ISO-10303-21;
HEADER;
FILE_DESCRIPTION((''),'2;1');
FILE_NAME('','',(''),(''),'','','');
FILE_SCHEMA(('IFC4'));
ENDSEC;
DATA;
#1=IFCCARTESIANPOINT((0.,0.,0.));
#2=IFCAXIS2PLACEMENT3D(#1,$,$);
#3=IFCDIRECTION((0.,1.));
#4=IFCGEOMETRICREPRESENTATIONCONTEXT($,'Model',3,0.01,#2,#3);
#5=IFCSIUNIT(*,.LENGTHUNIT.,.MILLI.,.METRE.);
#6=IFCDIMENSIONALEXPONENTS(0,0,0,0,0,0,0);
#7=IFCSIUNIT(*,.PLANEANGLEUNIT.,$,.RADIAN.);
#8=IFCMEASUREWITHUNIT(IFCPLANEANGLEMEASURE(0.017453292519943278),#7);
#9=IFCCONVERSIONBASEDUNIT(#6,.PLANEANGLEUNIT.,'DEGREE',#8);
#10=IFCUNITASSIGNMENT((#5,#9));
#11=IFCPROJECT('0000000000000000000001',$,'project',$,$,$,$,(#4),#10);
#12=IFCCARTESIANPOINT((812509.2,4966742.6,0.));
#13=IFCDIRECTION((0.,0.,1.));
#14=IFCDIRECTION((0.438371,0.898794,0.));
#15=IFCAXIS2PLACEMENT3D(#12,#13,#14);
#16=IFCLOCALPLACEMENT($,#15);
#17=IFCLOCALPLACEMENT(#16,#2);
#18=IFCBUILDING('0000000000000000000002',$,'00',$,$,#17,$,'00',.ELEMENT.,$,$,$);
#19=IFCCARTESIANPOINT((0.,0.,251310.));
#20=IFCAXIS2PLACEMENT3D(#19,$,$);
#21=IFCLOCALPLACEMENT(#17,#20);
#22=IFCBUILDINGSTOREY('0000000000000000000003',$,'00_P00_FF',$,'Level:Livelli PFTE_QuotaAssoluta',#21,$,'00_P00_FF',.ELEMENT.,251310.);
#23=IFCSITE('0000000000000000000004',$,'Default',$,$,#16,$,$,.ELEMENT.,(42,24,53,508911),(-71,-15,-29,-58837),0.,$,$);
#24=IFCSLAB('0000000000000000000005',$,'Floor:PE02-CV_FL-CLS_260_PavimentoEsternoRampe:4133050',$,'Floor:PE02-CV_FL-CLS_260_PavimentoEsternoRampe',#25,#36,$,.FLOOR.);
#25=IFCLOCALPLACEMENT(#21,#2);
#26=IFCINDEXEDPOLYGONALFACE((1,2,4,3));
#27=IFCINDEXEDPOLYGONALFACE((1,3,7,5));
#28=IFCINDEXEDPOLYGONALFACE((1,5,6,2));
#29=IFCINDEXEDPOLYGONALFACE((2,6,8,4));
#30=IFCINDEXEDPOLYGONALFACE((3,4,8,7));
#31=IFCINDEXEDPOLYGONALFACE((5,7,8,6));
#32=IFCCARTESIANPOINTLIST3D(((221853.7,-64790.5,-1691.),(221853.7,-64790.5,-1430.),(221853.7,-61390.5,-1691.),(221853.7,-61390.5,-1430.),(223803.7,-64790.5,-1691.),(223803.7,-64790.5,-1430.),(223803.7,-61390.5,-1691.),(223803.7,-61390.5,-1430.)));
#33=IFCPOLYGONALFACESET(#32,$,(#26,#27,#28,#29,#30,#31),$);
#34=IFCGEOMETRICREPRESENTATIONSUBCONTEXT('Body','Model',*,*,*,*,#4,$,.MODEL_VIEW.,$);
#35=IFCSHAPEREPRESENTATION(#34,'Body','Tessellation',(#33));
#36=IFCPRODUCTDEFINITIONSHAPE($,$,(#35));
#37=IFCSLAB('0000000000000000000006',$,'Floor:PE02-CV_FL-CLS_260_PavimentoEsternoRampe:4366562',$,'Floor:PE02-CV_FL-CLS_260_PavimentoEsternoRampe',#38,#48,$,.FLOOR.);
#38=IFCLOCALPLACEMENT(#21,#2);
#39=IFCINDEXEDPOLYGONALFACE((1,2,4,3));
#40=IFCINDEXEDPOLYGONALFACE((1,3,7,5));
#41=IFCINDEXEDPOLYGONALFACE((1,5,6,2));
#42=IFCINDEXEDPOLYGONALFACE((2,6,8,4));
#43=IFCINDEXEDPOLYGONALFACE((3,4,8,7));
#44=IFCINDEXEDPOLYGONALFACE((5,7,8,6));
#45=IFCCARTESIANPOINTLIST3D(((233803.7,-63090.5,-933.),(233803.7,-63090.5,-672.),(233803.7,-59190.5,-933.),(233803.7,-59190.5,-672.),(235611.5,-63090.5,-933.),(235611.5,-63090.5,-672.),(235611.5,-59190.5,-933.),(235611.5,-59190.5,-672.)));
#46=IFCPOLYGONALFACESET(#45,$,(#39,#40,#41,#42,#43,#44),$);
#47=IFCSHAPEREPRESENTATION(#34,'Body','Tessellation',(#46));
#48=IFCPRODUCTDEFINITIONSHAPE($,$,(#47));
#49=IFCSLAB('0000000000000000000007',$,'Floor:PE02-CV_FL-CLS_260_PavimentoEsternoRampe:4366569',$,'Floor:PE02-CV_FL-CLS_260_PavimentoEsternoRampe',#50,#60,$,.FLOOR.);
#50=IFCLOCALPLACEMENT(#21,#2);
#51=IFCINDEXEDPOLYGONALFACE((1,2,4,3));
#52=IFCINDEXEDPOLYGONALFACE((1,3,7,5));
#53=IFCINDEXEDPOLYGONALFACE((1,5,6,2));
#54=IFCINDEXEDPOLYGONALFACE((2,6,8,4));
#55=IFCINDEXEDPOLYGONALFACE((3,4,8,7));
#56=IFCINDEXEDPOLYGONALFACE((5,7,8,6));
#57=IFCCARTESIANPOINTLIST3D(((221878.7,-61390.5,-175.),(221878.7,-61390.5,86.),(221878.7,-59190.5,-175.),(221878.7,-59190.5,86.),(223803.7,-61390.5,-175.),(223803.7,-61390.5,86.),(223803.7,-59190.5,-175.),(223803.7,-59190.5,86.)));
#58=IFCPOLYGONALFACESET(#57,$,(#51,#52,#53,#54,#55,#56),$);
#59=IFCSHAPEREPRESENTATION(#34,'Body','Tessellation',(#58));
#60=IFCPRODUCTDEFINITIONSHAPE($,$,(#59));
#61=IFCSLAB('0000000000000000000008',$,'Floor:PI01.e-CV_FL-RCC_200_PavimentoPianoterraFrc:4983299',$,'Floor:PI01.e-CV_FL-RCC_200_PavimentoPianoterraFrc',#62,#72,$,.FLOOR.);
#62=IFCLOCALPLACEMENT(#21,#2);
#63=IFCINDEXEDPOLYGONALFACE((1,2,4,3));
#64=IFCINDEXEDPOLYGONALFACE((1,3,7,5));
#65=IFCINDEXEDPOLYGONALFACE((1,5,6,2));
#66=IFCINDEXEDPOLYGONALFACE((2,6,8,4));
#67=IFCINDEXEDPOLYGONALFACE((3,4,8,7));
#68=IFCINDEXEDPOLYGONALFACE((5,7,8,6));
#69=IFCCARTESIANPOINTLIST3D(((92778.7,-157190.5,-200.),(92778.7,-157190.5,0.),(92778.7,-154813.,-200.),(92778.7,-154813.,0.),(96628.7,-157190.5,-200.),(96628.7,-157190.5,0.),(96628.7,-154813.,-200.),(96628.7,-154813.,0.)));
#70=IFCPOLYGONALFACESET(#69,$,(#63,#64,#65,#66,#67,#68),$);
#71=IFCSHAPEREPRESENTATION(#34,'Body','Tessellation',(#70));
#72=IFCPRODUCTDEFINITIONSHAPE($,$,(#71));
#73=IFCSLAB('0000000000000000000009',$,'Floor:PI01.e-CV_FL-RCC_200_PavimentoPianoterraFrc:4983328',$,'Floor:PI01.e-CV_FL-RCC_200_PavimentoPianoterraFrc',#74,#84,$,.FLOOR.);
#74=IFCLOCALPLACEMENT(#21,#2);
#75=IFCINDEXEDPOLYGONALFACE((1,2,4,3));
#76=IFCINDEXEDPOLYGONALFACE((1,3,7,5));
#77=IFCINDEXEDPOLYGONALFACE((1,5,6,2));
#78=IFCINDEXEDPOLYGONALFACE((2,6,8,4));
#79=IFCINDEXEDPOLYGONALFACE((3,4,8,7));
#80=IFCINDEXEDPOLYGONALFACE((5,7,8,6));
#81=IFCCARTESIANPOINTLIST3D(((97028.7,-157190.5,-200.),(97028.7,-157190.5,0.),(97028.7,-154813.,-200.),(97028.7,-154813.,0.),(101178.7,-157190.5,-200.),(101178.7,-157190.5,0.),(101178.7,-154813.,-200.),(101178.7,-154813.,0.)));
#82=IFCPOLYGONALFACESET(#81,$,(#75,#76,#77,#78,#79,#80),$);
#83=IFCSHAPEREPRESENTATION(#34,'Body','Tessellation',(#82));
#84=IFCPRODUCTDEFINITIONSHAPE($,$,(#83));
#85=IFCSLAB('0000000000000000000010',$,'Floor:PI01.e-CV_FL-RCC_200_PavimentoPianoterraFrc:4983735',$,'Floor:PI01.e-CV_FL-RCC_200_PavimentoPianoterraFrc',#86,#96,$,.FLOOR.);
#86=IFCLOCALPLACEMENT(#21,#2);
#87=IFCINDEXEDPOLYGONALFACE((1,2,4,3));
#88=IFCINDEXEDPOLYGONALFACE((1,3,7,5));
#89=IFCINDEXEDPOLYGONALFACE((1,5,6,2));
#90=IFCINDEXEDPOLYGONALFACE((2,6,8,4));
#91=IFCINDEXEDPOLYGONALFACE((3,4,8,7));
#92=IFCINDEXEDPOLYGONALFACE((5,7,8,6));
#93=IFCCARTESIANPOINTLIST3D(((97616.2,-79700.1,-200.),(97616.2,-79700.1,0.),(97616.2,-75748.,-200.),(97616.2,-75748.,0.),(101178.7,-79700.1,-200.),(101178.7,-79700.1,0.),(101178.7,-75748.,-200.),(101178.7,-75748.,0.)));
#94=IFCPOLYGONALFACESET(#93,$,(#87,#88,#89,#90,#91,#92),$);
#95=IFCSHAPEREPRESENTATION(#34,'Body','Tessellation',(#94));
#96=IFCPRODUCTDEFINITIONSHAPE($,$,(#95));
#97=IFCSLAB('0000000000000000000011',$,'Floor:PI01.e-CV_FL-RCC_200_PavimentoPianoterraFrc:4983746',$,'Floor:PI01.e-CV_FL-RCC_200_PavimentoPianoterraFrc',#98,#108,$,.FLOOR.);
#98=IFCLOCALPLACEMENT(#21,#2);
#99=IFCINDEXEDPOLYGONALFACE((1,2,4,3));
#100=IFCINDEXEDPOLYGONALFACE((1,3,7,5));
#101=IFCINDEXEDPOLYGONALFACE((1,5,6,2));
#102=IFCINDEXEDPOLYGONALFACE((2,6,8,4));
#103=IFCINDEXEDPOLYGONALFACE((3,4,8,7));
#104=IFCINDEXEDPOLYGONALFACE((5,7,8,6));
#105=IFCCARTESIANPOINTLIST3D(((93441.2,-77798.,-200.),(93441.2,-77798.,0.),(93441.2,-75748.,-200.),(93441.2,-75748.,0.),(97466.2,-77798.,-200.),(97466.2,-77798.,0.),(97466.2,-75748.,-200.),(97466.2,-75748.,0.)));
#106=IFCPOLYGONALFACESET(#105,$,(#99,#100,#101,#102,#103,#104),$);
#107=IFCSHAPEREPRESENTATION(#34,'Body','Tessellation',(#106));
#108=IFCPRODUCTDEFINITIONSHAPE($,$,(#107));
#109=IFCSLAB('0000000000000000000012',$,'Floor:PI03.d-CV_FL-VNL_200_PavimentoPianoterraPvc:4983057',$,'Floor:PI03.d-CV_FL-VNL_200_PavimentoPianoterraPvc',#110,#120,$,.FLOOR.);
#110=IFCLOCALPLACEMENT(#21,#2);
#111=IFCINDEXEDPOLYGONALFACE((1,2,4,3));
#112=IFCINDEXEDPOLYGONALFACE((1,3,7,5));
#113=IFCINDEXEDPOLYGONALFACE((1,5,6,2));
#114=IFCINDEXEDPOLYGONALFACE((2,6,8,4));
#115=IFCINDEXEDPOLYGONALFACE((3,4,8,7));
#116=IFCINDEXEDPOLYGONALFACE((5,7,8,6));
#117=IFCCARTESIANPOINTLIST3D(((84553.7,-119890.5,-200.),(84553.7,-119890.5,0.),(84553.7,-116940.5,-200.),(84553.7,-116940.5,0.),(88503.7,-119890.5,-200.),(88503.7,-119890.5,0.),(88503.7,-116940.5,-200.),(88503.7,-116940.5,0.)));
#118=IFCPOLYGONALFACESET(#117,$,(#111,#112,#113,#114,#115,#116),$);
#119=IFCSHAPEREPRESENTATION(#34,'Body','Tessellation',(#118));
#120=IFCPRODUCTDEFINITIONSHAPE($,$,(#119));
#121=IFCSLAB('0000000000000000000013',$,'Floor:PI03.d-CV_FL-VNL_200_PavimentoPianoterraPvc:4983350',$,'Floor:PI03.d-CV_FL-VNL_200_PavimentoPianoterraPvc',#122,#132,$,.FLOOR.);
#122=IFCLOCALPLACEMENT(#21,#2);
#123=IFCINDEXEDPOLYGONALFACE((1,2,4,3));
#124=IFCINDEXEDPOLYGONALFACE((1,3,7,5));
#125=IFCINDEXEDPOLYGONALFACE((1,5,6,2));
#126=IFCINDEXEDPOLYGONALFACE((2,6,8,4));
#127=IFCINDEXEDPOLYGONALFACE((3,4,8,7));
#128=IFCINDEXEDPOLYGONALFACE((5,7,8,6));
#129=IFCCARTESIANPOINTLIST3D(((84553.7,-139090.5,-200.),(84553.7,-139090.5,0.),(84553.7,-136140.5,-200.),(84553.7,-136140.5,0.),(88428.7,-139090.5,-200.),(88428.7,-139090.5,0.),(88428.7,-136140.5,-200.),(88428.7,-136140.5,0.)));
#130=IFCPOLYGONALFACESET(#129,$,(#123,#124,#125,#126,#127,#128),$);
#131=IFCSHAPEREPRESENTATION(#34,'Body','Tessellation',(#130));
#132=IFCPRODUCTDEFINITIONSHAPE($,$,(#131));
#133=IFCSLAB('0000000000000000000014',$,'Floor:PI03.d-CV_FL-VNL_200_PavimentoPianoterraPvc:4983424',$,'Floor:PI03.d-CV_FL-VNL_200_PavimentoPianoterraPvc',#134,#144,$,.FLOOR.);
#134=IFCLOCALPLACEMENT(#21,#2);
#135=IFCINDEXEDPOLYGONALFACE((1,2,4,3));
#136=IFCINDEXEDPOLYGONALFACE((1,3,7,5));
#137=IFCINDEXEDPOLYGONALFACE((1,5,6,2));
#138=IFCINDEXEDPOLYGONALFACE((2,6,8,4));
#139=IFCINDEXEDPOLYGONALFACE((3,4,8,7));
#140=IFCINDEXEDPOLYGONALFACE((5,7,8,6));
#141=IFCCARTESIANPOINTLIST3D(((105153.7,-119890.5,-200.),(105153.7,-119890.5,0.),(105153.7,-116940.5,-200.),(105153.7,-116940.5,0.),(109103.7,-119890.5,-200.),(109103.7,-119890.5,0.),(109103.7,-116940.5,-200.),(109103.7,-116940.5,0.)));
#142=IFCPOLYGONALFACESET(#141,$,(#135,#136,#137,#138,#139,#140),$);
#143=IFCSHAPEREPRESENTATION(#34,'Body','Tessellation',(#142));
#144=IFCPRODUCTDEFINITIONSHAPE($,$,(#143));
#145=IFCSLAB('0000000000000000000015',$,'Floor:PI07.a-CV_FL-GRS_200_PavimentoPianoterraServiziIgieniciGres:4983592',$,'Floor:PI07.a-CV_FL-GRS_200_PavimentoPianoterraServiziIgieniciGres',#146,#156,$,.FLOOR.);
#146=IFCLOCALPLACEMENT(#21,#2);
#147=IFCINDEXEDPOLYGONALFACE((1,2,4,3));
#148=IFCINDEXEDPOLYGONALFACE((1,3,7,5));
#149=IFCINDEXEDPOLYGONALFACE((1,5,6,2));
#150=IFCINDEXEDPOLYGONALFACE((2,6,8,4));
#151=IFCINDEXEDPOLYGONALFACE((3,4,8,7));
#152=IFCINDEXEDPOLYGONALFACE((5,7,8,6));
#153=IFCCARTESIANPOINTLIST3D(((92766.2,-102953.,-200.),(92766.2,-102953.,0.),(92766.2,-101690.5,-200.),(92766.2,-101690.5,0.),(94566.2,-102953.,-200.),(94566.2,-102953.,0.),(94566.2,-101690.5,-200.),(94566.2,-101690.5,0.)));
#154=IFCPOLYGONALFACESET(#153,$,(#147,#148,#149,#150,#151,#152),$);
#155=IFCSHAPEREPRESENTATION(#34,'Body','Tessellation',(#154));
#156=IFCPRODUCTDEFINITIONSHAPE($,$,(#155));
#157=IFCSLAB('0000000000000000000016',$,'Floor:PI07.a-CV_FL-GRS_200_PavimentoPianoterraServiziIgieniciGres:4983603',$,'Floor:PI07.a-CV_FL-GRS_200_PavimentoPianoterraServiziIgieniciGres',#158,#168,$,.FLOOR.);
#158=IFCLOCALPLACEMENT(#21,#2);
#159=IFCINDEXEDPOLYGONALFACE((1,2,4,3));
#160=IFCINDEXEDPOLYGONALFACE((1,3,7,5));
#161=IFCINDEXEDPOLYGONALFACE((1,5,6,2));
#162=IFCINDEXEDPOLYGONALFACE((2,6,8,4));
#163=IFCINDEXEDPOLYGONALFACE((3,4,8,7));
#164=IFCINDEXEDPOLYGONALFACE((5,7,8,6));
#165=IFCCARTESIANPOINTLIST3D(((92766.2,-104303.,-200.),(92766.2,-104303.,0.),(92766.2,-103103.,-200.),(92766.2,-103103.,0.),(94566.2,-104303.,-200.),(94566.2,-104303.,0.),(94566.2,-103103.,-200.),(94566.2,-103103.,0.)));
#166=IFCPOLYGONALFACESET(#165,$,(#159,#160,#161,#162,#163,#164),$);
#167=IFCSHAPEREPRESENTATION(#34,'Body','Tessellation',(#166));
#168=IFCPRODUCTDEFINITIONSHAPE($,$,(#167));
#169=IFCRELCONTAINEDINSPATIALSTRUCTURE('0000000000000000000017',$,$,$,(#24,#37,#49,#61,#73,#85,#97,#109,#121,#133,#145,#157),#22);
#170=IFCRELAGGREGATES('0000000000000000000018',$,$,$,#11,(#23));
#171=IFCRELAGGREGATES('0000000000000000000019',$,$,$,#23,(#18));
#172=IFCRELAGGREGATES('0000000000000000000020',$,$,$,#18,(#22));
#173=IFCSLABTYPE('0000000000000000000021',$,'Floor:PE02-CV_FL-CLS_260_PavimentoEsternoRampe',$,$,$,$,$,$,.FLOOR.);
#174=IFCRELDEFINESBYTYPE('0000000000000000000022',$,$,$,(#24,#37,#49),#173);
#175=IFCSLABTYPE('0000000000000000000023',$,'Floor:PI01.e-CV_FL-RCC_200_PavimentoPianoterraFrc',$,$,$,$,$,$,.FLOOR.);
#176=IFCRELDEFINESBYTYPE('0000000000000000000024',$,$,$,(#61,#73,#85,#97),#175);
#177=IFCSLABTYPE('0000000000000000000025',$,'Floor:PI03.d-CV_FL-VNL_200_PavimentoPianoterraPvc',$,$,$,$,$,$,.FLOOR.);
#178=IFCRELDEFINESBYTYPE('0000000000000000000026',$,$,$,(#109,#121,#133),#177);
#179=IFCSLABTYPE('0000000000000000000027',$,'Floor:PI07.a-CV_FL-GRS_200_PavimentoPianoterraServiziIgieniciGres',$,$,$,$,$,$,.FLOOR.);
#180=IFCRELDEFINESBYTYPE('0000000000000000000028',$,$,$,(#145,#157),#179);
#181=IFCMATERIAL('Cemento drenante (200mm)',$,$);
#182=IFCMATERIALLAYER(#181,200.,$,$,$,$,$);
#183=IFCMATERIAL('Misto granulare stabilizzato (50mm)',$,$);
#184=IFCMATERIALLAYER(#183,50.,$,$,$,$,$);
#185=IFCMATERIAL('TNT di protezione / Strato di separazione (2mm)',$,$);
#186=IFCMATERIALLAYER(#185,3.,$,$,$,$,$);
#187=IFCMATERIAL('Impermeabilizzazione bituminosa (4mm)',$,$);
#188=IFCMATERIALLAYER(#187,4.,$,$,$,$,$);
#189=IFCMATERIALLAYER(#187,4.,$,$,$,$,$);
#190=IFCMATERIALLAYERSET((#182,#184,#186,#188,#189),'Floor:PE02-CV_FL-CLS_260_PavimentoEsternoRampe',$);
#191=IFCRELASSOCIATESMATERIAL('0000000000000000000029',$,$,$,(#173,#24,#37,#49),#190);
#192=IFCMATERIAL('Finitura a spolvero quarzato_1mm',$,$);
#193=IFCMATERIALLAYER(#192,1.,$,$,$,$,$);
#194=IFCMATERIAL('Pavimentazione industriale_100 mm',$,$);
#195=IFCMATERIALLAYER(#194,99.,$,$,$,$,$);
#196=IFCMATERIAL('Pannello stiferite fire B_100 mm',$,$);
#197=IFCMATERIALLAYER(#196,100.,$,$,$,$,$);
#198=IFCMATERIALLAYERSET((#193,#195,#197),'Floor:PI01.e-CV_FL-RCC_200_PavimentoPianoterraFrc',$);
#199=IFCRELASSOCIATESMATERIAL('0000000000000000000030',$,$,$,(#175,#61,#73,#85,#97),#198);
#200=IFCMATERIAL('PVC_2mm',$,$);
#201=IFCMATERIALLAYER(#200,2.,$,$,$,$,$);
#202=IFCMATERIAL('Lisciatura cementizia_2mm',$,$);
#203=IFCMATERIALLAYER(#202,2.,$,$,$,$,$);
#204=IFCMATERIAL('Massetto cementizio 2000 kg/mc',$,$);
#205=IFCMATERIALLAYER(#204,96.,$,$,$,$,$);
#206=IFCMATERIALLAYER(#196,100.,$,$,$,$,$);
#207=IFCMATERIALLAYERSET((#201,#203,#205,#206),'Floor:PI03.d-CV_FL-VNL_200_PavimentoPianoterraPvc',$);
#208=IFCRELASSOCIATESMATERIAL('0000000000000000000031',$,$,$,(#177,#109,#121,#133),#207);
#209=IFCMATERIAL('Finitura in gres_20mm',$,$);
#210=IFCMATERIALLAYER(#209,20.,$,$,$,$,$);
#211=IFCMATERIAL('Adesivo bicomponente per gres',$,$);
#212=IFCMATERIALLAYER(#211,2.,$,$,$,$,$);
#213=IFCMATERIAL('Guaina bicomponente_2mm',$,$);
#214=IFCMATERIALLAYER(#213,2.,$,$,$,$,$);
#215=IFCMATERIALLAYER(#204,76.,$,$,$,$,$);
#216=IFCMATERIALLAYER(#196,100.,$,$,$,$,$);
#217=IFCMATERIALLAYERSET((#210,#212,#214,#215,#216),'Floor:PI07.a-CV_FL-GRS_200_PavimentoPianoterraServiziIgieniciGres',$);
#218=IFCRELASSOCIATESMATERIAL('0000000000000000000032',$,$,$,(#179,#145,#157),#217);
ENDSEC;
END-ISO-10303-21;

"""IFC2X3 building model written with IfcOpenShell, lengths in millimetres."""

from ifc_helpers import new_model, entity, si_unit, converted_unit, direction, frame, frame_2d, origin, origin_2d_with_axis, place, context, subcontext, project, spatial, rectangle, extrude, material, layer, layer_set, layer_usage, type_object, element, save


model = new_model("IFC2X3")

# Units and contexts
model_context = context("Model", 3, precision=0.01, world=origin(), true_north=direction((0.0, 1.0)))
body_context = subcontext(model_context, "Body", "Model", "MODEL_VIEW")
ifc_project = project(units=[si_unit("LENGTHUNIT", "METRE", prefix="MILLI"), converted_unit("PLANEANGLEUNIT", "DEGREE", entity("IfcPlaneAngleMeasure", 0.017453292519943278), si_unit("PLANEANGLEUNIT", "RADIAN"), dimensions=[0, 0, 0, 0, 0, 0, 0])], contexts=[model_context])

# Site, building, storey
site_placement = place(None, frame((812509.2, 4966742.6, 0.0), z_axis=(0.0, 0.0, 1.0), x_axis=(0.438371, 0.898794, 0.0)))
site = spatial("IfcSite", under=ifc_project, at=site_placement, Name="Default", CompositionType="ELEMENT", RefLatitude=(42, 24, 53, 508911), RefLongitude=(-71, -15, -29, -58837), RefElevation=0.0)
building_placement = place(site_placement, origin())
building = spatial("IfcBuilding", under=site, at=building_placement, Name="00", LongName="00", CompositionType="ELEMENT")
storey_placement = place(building_placement, frame((0.0, 0.0, 251310.0)))
storey = spatial("IfcBuildingStorey", under=building, at=storey_placement, Name="00_P00_FF", ObjectType="Level:Livelli PFTE_QuotaAssoluta", LongName="00_P00_FF", CompositionType="ELEMENT", Elevation=251310.0)

# Slabs
ifc_material_1 = material(Name="Massetto cementizio 2000 kg/mc")
ifc_material_2 = material(Name="Pannello stiferite fire B_100 mm")
ifc_material_3 = material(Name="Cemento drenante (200mm)")
ifc_layer_1 = layer(ifc_material_3, 200.0)
ifc_material_4 = material(Name="Misto granulare stabilizzato (50mm)")
ifc_layer_2 = layer(ifc_material_4, 50.0)
ifc_material_5 = material(Name="TNT di protezione / Strato di separazione (2mm)")
ifc_layer_3 = layer(ifc_material_5, 3.0)
ifc_material_6 = material(Name="Impermeabilizzazione bituminosa (4mm)")
ifc_layer_4 = layer(ifc_material_6, 4.0)
ifc_layer_5 = layer(ifc_material_6, 4.0)
ifc_layer_set_1 = layer_set([ifc_layer_1, ifc_layer_2, ifc_layer_3, ifc_layer_4, ifc_layer_5], Name="Floor:PE02-CV_FL-CLS_260_PavimentoEsternoRampe")
ifc_layer_usage_1 = layer_usage(ifc_layer_set_1, "AXIS3", "POSITIVE", 0.0)
slab_type_1 = type_object("IfcSlabType", Name="Floor:PE02-CV_FL-CLS_260_PavimentoEsternoRampe", PredefinedType="FLOOR", material=ifc_layer_set_1)
slab_1_placement = place(storey_placement, origin())
element("IfcSlab", 1, at=slab_1_placement, inside=storey, type_object=slab_type_1, material=ifc_layer_usage_1, Name="Floor:PE02-CV_FL-CLS_260_PavimentoEsternoRampe:4133050", ObjectType="Floor:PE02-CV_FL-CLS_260_PavimentoEsternoRampe", PredefinedType="FLOOR", context=body_context, shape_type="SweptSolid", body=[
    extrude(rectangle(XDim=3400.0, YDim=1950.0, at=frame_2d((0.0, 0.0), x_axis=(1.0, 0.0))), frame((222828.7, -63090.5, -1430.0), z_axis=(0.0, 0.0, -1.0), x_axis=(0.0, 1.0, 0.0)), (0.0, 0.0, 1.0), 261.0),
])
ifc_layer_usage_2 = layer_usage(ifc_layer_set_1, "AXIS3", "POSITIVE", 0.0)
slab_2_placement = place(storey_placement, origin())
element("IfcSlab", 2, at=slab_2_placement, inside=storey, type_object=slab_type_1, material=ifc_layer_usage_2, Name="Floor:PE02-CV_FL-CLS_260_PavimentoEsternoRampe:4366562", ObjectType="Floor:PE02-CV_FL-CLS_260_PavimentoEsternoRampe", PredefinedType="FLOOR", context=body_context, shape_type="SweptSolid", body=[
    extrude(rectangle(XDim=3900.0, YDim=1807.8, at=origin_2d_with_axis()), frame((234707.6, -61140.5, -672.0), z_axis=(0.0, 0.0, -1.0), x_axis=(0.0, 1.0, 0.0)), (0.0, 0.0, 1.0), 261.0),
])
ifc_layer_usage_3 = layer_usage(ifc_layer_set_1, "AXIS3", "POSITIVE", 0.0)
slab_3_placement = place(storey_placement, origin())
element("IfcSlab", 3, at=slab_3_placement, inside=storey, type_object=slab_type_1, material=ifc_layer_usage_3, Name="Floor:PE02-CV_FL-CLS_260_PavimentoEsternoRampe:4366569", ObjectType="Floor:PE02-CV_FL-CLS_260_PavimentoEsternoRampe", PredefinedType="FLOOR", context=body_context, shape_type="SweptSolid", body=[
    extrude(rectangle(XDim=2200.0, YDim=1925.0, at=frame_2d((0.0, 0.0), x_axis=(1.0, 0.0))), frame((222841.2, -60290.5, 86.0), z_axis=(0.0, 0.0, -1.0), x_axis=(0.0, 1.0, 0.0)), (0.0, 0.0, 1.0), 261.0),
])
ifc_material_7 = material(Name="Finitura a spolvero quarzato_1mm")
ifc_layer_6 = layer(ifc_material_7, 1.0)
ifc_material_8 = material(Name="Pavimentazione industriale_100 mm")
ifc_layer_7 = layer(ifc_material_8, 99.0)
ifc_layer_8 = layer(ifc_material_2, 100.0)
ifc_layer_set_2 = layer_set([ifc_layer_6, ifc_layer_7, ifc_layer_8], Name="Floor:PI01.e-CV_FL-RCC_200_PavimentoPianoterraFrc")
slab_type_2 = type_object("IfcSlabType", Name="Floor:PI01.e-CV_FL-RCC_200_PavimentoPianoterraFrc", PredefinedType="FLOOR", material=ifc_layer_set_2)
ifc_layer_usage_4 = layer_usage(ifc_layer_set_2, "AXIS3", "POSITIVE", 0.0)
slab_4_placement = place(storey_placement, origin())
element("IfcSlab", 4, at=slab_4_placement, inside=storey, type_object=slab_type_2, material=ifc_layer_usage_4, Name="Floor:PI01.e-CV_FL-RCC_200_PavimentoPianoterraFrc:4983299", ObjectType="Floor:PI01.e-CV_FL-RCC_200_PavimentoPianoterraFrc", PredefinedType="FLOOR", context=body_context, shape_type="SweptSolid", body=[
    extrude(rectangle(XDim=2377.5, YDim=3850.0, at=origin_2d_with_axis()), frame((94703.7, -156001.7, 0.0), z_axis=(0.0, 0.0, -1.0), x_axis=(0.0, 1.0, 0.0)), (0.0, 0.0, 1.0), 200.0),
])
ifc_layer_usage_5 = layer_usage(ifc_layer_set_2, "AXIS3", "POSITIVE", 0.0)
slab_5_placement = place(storey_placement, origin())
element("IfcSlab", 5, at=slab_5_placement, inside=storey, type_object=slab_type_2, material=ifc_layer_usage_5, Name="Floor:PI01.e-CV_FL-RCC_200_PavimentoPianoterraFrc:4983328", ObjectType="Floor:PI01.e-CV_FL-RCC_200_PavimentoPianoterraFrc", PredefinedType="FLOOR", context=body_context, shape_type="SweptSolid", body=[
    extrude(rectangle(XDim=2377.5, YDim=4150.0, at=origin_2d_with_axis()), frame((99103.7, -156001.7, 0.0), z_axis=(0.0, 0.0, -1.0), x_axis=(0.0, 1.0, 0.0)), (0.0, 0.0, 1.0), 200.0),
])
ifc_layer_usage_6 = layer_usage(ifc_layer_set_2, "AXIS3", "POSITIVE", 0.0)
slab_6_placement = place(storey_placement, origin())
element("IfcSlab", 6, at=slab_6_placement, inside=storey, type_object=slab_type_2, material=ifc_layer_usage_6, Name="Floor:PI01.e-CV_FL-RCC_200_PavimentoPianoterraFrc:4983735", ObjectType="Floor:PI01.e-CV_FL-RCC_200_PavimentoPianoterraFrc", PredefinedType="FLOOR", context=body_context, shape_type="SweptSolid", body=[
    extrude(rectangle(XDim=3952.2, YDim=3562.5, at=frame_2d((0.0, 0.0), x_axis=(1.0, 0.0))), frame((99397.4, -77724.1, 0.0), z_axis=(0.0, 0.0, -1.0), x_axis=(0.0, 1.0, 0.0)), (0.0, 0.0, 1.0), 200.0),
])
ifc_layer_usage_7 = layer_usage(ifc_layer_set_2, "AXIS3", "POSITIVE", 0.0)
slab_7_placement = place(storey_placement, origin())
element("IfcSlab", 7, at=slab_7_placement, inside=storey, type_object=slab_type_2, material=ifc_layer_usage_7, Name="Floor:PI01.e-CV_FL-RCC_200_PavimentoPianoterraFrc:4983746", ObjectType="Floor:PI01.e-CV_FL-RCC_200_PavimentoPianoterraFrc", PredefinedType="FLOOR", context=body_context, shape_type="SweptSolid", body=[
    extrude(rectangle(XDim=2050.0, YDim=4025.0, at=frame_2d((0.0, 0.0), x_axis=(1.0, 0.0))), frame((95453.7, -76773.0, 0.0), z_axis=(0.0, 0.0, -1.0), x_axis=(0.0, 1.0, 0.0)), (0.0, 0.0, 1.0), 200.0),
])
ifc_material_9 = material(Name="PVC_2mm")
ifc_layer_9 = layer(ifc_material_9, 2.0)
ifc_material_10 = material(Name="Lisciatura cementizia_2mm")
ifc_layer_10 = layer(ifc_material_10, 2.0)
ifc_layer_11 = layer(ifc_material_1, 96.0)
ifc_layer_12 = layer(ifc_material_2, 100.0)
ifc_layer_set_3 = layer_set([ifc_layer_9, ifc_layer_10, ifc_layer_11, ifc_layer_12], Name="Floor:PI03.d-CV_FL-VNL_200_PavimentoPianoterraPvc")
ifc_layer_usage_8 = layer_usage(ifc_layer_set_3, "AXIS3", "POSITIVE", 0.0)
slab_type_3 = type_object("IfcSlabType", Name="Floor:PI03.d-CV_FL-VNL_200_PavimentoPianoterraPvc", PredefinedType="FLOOR", material=ifc_layer_set_3)
slab_8_placement = place(storey_placement, origin())
element("IfcSlab", 8, at=slab_8_placement, inside=storey, type_object=slab_type_3, material=ifc_layer_usage_8, Name="Floor:PI03.d-CV_FL-VNL_200_PavimentoPianoterraPvc:4983057", ObjectType="Floor:PI03.d-CV_FL-VNL_200_PavimentoPianoterraPvc", PredefinedType="FLOOR", context=body_context, shape_type="SweptSolid", body=[
    extrude(rectangle(XDim=2950.0, YDim=3950.0, at=origin_2d_with_axis()), frame((86528.7, -118415.5, 0.0), z_axis=(0.0, 0.0, -1.0), x_axis=(0.0, 1.0, 0.0)), (0.0, 0.0, 1.0), 200.0),
])
ifc_layer_usage_9 = layer_usage(ifc_layer_set_3, "AXIS3", "POSITIVE", 0.0)
slab_9_placement = place(storey_placement, origin())
element("IfcSlab", 9, at=slab_9_placement, inside=storey, type_object=slab_type_3, material=ifc_layer_usage_9, Name="Floor:PI03.d-CV_FL-VNL_200_PavimentoPianoterraPvc:4983350", ObjectType="Floor:PI03.d-CV_FL-VNL_200_PavimentoPianoterraPvc", PredefinedType="FLOOR", context=body_context, shape_type="SweptSolid", body=[
    extrude(rectangle(XDim=2950.0, YDim=3875.0, at=origin_2d_with_axis()), frame((86491.2, -137615.5, 0.0), z_axis=(0.0, 0.0, -1.0), x_axis=(0.0, 1.0, 0.0)), (0.0, 0.0, 1.0), 200.0),
])
ifc_layer_usage_10 = layer_usage(ifc_layer_set_3, "AXIS3", "POSITIVE", 0.0)
slab_10_placement = place(storey_placement, origin())
element("IfcSlab", 10, at=slab_10_placement, inside=storey, type_object=slab_type_3, material=ifc_layer_usage_10, Name="Floor:PI03.d-CV_FL-VNL_200_PavimentoPianoterraPvc:4983424", ObjectType="Floor:PI03.d-CV_FL-VNL_200_PavimentoPianoterraPvc", PredefinedType="FLOOR", context=body_context, shape_type="SweptSolid", body=[
    extrude(rectangle(XDim=2950.0, YDim=3950.0, at=frame_2d((0.0, 0.0), x_axis=(1.0, 0.0))), frame((107128.7, -118415.5, 0.0), z_axis=(0.0, 0.0, -1.0), x_axis=(0.0, 1.0, 0.0)), (0.0, 0.0, 1.0), 200.0),
])
ifc_material_11 = material(Name="Finitura in gres_20mm")
ifc_layer_13 = layer(ifc_material_11, 20.0)
ifc_material_12 = material(Name="Adesivo bicomponente per gres")
ifc_layer_14 = layer(ifc_material_12, 2.0)
ifc_material_13 = material(Name="Guaina bicomponente_2mm")
ifc_layer_15 = layer(ifc_material_13, 2.0)
ifc_layer_16 = layer(ifc_material_1, 76.0)
ifc_layer_17 = layer(ifc_material_2, 100.0)
ifc_layer_set_4 = layer_set([ifc_layer_13, ifc_layer_14, ifc_layer_15, ifc_layer_16, ifc_layer_17], Name="Floor:PI07.a-CV_FL-GRS_200_PavimentoPianoterraServiziIgieniciGres")
slab_type_4 = type_object("IfcSlabType", Name="Floor:PI07.a-CV_FL-GRS_200_PavimentoPianoterraServiziIgieniciGres", PredefinedType="FLOOR", material=ifc_layer_set_4)
ifc_layer_usage_11 = layer_usage(ifc_layer_set_4, "AXIS3", "POSITIVE", 0.0)
slab_11_placement = place(storey_placement, origin())
element("IfcSlab", 11, at=slab_11_placement, inside=storey, type_object=slab_type_4, material=ifc_layer_usage_11, Name="Floor:PI07.a-CV_FL-GRS_200_PavimentoPianoterraServiziIgieniciGres:4983592", ObjectType="Floor:PI07.a-CV_FL-GRS_200_PavimentoPianoterraServiziIgieniciGres", PredefinedType="FLOOR", context=body_context, shape_type="SweptSolid", body=[
    extrude(rectangle(XDim=1262.5, YDim=1800.0, at=frame_2d((0.0, 0.0), x_axis=(1.0, 0.0))), frame((93666.2, -102321.7, 0.0), z_axis=(0.0, 0.0, -1.0), x_axis=(0.0, 1.0, 0.0)), (0.0, 0.0, 1.0), 200.0),
])
ifc_layer_usage_12 = layer_usage(ifc_layer_set_4, "AXIS3", "POSITIVE", 0.0)
slab_12_placement = place(storey_placement, origin())
element("IfcSlab", 12, at=slab_12_placement, inside=storey, type_object=slab_type_4, material=ifc_layer_usage_12, Name="Floor:PI07.a-CV_FL-GRS_200_PavimentoPianoterraServiziIgieniciGres:4983603", ObjectType="Floor:PI07.a-CV_FL-GRS_200_PavimentoPianoterraServiziIgieniciGres", PredefinedType="FLOOR", context=body_context, shape_type="SweptSolid", body=[
    extrude(rectangle(XDim=1200.0, YDim=1800.0, at=origin_2d_with_axis()), frame((93666.2, -103703.0, 0.0), z_axis=(0.0, 0.0, -1.0), x_axis=(0.0, 1.0, 0.0)), (0.0, 0.0, 1.0), 200.0),
])

save(model, "model.ifc")
